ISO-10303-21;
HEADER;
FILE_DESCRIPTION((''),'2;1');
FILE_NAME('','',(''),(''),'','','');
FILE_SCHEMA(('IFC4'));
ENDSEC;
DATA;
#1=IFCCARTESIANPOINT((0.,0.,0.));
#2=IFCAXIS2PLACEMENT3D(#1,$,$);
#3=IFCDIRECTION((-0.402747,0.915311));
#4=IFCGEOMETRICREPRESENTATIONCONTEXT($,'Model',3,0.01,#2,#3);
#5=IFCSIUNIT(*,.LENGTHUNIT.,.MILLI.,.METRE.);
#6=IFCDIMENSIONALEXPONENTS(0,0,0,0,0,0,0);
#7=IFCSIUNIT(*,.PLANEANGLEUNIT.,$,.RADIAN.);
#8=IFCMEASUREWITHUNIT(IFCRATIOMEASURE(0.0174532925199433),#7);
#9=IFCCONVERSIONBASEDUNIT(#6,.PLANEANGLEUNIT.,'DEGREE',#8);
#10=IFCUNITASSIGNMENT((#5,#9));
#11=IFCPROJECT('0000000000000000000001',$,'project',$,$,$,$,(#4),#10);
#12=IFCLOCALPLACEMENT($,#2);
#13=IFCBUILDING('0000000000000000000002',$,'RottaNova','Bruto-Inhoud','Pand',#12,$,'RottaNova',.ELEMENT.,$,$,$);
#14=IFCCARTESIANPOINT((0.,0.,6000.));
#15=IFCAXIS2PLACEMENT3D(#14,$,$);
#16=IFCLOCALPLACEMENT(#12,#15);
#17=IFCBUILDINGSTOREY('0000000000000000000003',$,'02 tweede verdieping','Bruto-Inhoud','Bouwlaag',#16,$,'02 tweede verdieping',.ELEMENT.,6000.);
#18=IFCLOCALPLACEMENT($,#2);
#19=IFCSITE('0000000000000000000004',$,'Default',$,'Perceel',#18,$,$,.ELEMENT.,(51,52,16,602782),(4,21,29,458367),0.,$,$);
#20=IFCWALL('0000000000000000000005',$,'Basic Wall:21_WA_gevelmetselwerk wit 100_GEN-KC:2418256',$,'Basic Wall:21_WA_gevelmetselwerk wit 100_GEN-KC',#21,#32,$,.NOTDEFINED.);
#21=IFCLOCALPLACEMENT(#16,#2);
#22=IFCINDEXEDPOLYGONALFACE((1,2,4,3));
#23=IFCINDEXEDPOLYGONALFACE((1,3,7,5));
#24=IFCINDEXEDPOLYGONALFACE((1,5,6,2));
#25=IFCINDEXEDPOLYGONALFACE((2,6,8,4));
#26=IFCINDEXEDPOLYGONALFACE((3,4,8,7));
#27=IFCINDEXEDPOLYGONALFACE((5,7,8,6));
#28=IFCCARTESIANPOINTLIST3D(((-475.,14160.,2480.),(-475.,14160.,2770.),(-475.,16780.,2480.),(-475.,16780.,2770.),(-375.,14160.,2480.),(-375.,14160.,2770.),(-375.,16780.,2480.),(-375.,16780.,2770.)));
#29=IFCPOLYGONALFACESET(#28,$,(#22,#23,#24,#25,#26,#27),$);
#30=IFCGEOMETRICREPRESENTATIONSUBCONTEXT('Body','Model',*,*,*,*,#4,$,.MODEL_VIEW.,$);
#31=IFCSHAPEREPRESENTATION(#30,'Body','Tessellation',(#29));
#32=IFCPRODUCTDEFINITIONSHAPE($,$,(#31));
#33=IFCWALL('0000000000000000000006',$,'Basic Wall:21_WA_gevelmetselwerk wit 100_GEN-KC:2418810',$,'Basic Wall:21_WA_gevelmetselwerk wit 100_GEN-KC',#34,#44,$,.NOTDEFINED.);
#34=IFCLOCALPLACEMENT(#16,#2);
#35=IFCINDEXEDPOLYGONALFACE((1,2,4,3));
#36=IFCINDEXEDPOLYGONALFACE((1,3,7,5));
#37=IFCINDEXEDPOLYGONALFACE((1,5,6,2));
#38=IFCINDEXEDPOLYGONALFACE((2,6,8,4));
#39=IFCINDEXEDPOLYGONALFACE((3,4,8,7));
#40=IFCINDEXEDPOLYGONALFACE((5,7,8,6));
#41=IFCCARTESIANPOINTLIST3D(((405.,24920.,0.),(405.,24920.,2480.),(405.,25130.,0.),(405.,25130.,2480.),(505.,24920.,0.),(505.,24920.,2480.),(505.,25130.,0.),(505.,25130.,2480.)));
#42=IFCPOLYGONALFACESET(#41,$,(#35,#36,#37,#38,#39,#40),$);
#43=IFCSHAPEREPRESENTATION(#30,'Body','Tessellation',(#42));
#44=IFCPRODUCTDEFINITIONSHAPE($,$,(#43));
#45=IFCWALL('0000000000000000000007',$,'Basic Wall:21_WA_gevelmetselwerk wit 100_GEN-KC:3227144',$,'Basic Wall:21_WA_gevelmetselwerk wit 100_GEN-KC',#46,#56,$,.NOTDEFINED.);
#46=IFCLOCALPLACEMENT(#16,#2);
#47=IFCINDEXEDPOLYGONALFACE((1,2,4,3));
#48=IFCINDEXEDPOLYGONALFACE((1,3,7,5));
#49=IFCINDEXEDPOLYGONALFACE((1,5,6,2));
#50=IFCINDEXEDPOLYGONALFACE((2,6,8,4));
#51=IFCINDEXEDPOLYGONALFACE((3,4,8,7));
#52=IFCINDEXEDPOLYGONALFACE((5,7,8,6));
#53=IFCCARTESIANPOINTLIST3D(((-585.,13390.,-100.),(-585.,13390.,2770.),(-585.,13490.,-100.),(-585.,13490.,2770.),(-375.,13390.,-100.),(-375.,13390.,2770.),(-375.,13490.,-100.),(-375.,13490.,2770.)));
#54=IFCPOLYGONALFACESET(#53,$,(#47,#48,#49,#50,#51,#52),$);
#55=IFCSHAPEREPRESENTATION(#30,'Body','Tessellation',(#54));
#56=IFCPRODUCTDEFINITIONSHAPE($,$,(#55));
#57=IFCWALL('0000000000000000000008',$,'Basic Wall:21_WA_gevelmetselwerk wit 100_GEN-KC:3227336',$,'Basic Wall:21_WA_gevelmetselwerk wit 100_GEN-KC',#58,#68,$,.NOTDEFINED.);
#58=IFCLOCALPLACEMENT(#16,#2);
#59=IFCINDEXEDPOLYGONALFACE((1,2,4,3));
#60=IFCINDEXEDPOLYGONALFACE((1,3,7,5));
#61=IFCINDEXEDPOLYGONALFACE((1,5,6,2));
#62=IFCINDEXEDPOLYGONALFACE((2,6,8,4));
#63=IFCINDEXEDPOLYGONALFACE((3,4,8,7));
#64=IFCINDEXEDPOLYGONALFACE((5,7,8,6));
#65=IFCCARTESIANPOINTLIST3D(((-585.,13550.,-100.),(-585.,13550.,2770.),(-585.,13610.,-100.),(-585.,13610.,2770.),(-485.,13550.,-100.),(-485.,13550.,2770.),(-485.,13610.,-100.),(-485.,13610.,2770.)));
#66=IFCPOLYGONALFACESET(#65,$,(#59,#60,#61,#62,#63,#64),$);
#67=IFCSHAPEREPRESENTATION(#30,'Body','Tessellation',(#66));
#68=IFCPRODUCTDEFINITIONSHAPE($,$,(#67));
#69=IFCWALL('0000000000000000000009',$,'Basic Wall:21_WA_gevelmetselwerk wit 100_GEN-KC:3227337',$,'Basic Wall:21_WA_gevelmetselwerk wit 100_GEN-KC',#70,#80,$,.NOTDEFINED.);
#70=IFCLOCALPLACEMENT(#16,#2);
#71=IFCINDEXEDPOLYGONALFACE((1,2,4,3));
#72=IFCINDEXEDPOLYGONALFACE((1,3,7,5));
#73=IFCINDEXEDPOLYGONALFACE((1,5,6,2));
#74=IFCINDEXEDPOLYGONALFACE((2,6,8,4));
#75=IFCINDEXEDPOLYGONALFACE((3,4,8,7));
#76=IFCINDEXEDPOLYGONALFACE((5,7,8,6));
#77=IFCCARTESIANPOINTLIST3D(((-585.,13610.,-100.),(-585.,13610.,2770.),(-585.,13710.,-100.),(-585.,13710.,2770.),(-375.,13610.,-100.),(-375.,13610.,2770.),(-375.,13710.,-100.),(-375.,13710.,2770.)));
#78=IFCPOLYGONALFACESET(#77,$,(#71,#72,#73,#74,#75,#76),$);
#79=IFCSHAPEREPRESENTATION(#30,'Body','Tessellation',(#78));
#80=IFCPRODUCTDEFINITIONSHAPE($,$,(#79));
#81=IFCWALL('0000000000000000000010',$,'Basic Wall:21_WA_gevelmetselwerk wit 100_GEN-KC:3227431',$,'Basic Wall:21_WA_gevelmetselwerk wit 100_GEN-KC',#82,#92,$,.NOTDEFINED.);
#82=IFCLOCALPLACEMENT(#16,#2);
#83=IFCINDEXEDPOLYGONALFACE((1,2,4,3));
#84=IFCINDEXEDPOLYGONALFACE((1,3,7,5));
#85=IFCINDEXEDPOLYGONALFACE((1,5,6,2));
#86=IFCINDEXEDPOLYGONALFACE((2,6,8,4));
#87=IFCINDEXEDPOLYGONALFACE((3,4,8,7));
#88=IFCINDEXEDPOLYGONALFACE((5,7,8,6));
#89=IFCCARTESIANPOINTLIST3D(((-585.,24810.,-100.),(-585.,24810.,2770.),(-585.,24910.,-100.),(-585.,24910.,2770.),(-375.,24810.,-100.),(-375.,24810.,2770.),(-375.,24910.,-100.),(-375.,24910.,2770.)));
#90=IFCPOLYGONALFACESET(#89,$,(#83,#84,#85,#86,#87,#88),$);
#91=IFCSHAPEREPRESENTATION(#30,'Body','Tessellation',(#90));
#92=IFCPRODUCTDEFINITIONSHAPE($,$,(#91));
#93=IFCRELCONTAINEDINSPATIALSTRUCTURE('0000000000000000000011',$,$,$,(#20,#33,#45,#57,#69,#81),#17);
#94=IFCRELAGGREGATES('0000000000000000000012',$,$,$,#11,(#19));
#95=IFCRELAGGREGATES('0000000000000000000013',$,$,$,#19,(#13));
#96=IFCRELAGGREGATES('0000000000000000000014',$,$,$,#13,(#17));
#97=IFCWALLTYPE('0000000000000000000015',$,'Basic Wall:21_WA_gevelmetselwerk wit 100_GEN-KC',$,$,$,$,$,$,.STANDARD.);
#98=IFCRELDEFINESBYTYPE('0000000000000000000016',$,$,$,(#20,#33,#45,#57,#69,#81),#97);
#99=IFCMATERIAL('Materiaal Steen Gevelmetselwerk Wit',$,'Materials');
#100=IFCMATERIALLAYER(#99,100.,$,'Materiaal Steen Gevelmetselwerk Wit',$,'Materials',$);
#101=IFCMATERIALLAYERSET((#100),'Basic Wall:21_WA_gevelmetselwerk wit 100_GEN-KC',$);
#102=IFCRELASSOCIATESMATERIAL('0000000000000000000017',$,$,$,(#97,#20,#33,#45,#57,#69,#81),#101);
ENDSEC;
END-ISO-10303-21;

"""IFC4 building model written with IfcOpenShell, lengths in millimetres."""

from ifc_helpers import new_model, entity, si_unit, converted_unit, direction, frame, frame_2d, origin, place, context, subcontext, project, spatial, rectangle, extrude, material, layer, layer_set, type_object, element, save


model = new_model("IFC4")

# Units and contexts
model_context = context("Model", 3, precision=0.01, world=origin(), true_north=direction((-0.402747, 0.915311)))
body_context = subcontext(model_context, "Body", "Model", "MODEL_VIEW")
ifc_project = project(units=[si_unit("LENGTHUNIT", "METRE", prefix="MILLI"), converted_unit("PLANEANGLEUNIT", "DEGREE", entity("IfcRatioMeasure", 0.0174532925199433), si_unit("PLANEANGLEUNIT", "RADIAN"), dimensions=[0, 0, 0, 0, 0, 0, 0])], contexts=[model_context])

# Site, building, storey
site_placement = place(None, origin())
site = spatial("IfcSite", under=ifc_project, at=site_placement, Name="Default", ObjectType="Perceel", CompositionType="ELEMENT", RefLatitude=(51, 52, 16, 602782), RefLongitude=(4, 21, 29, 458367), RefElevation=0.0)
building_placement = place(None, origin())
building = spatial("IfcBuilding", under=site, at=building_placement, Name="RottaNova", Description="Bruto-Inhoud", ObjectType="Pand", LongName="RottaNova", CompositionType="ELEMENT")
storey_placement = place(building_placement, frame((0.0, 0.0, 6000.0)))
storey = spatial("IfcBuildingStorey", under=building, at=storey_placement, Name="02 tweede verdieping", Description="Bruto-Inhoud", ObjectType="Bouwlaag", LongName="02 tweede verdieping", CompositionType="ELEMENT", Elevation=6000.0)

# Walls
ifc_material_1 = material(Name="Materiaal Steen Gevelmetselwerk Wit", Category="Materials")
ifc_layer_1 = layer(ifc_material_1, 100.0, Name="Materiaal Steen Gevelmetselwerk Wit", Category="Materials")
ifc_layer_set_1 = layer_set([ifc_layer_1], Name="Basic Wall:21_WA_gevelmetselwerk wit 100_GEN-KC")
wall_type_1 = type_object("IfcWallType", Name="Basic Wall:21_WA_gevelmetselwerk wit 100_GEN-KC", PredefinedType="STANDARD", material=ifc_layer_set_1)
wall_1_placement = place(storey_placement, frame((-425.0, 16780.0, 2480.0), z_axis=(0.0, 0.0, 1.0), x_axis=(0.0, -1.0, 0.0)))
element("IfcWall", 1, at=wall_1_placement, inside=storey, type_object=wall_type_1, material=ifc_layer_set_1, Name="Basic Wall:21_WA_gevelmetselwerk wit 100_GEN-KC:2418256", ObjectType="Basic Wall:21_WA_gevelmetselwerk wit 100_GEN-KC", PredefinedType="NOTDEFINED", context=body_context, shape_type="SweptSolid", body=[
    extrude(rectangle(XDim=2620.0, YDim=100.0, at=frame_2d((1310.0, 0.0), x_axis=(-1.0, 0.0))), origin(), (0.0, 0.0, 1.0), 290.0),
])
wall_2_placement = place(storey_placement, frame((455.0, 24920.0, 0.0), z_axis=(0.0, 0.0, 1.0), x_axis=(0.0, 1.0, 0.0)))
element("IfcWall", 2, at=wall_2_placement, inside=storey, type_object=wall_type_1, material=ifc_layer_set_1, Name="Basic Wall:21_WA_gevelmetselwerk wit 100_GEN-KC:2418810", ObjectType="Basic Wall:21_WA_gevelmetselwerk wit 100_GEN-KC", PredefinedType="NOTDEFINED", context=body_context, shape_type="SweptSolid", body=[
    extrude(rectangle(XDim=210.0, YDim=100.0, at=frame_2d((105.0, 0.0), x_axis=(-1.0, 0.0))), origin(), (0.0, 0.0, 1.0), 2480.0),
])
wall_3_placement = place(storey_placement, frame((-585.0, 13440.0, -100.0)))
element("IfcWall", 3, at=wall_3_placement, inside=storey, type_object=wall_type_1, material=ifc_layer_set_1, Name="Basic Wall:21_WA_gevelmetselwerk wit 100_GEN-KC:3227144", ObjectType="Basic Wall:21_WA_gevelmetselwerk wit 100_GEN-KC", PredefinedType="NOTDEFINED", context=body_context, shape_type="SweptSolid", body=[
    extrude(rectangle(XDim=210.0, YDim=100.0, at=frame_2d((105.0, 0.0), x_axis=(-1.0, 0.0))), origin(), (0.0, 0.0, 1.0), 2870.0),
])
wall_4_placement = place(storey_placement, frame((-535.0, 13550.0, -100.0), z_axis=(0.0, 0.0, 1.0), x_axis=(0.0, 1.0, 0.0)))
element("IfcWall", 4, at=wall_4_placement, inside=storey, type_object=wall_type_1, material=ifc_layer_set_1, Name="Basic Wall:21_WA_gevelmetselwerk wit 100_GEN-KC:3227336", ObjectType="Basic Wall:21_WA_gevelmetselwerk wit 100_GEN-KC", PredefinedType="NOTDEFINED", context=body_context, shape_type="SweptSolid", body=[
    extrude(rectangle(XDim=60.0, YDim=100.0, at=frame_2d((30.0, 0.0), x_axis=(-1.0, 0.0))), origin(), (0.0, 0.0, 1.0), 2870.0),
])
wall_5_placement = place(storey_placement, frame((-585.0, 13660.0, -100.0)))
element("IfcWall", 5, at=wall_5_placement, inside=storey, type_object=wall_type_1, material=ifc_layer_set_1, Name="Basic Wall:21_WA_gevelmetselwerk wit 100_GEN-KC:3227337", ObjectType="Basic Wall:21_WA_gevelmetselwerk wit 100_GEN-KC", PredefinedType="NOTDEFINED", context=body_context, shape_type="SweptSolid", body=[
    extrude(rectangle(XDim=210.0, YDim=100.0, at=frame_2d((105.0, 0.0), x_axis=(-1.0, 0.0))), origin(), (0.0, 0.0, 1.0), 2870.0),
])
wall_6_placement = place(storey_placement, frame((-585.0, 24860.0, -100.0)))
element("IfcWall", 6, at=wall_6_placement, inside=storey, type_object=wall_type_1, material=ifc_layer_set_1, Name="Basic Wall:21_WA_gevelmetselwerk wit 100_GEN-KC:3227431", ObjectType="Basic Wall:21_WA_gevelmetselwerk wit 100_GEN-KC", PredefinedType="NOTDEFINED", context=body_context, shape_type="SweptSolid", body=[
    extrude(rectangle(XDim=210.0, YDim=100.0, at=frame_2d((105.0, 0.0), x_axis=(-1.0, 0.0))), origin(), (0.0, 0.0, 1.0), 2870.0),
])

save(model, "model.ifc")
